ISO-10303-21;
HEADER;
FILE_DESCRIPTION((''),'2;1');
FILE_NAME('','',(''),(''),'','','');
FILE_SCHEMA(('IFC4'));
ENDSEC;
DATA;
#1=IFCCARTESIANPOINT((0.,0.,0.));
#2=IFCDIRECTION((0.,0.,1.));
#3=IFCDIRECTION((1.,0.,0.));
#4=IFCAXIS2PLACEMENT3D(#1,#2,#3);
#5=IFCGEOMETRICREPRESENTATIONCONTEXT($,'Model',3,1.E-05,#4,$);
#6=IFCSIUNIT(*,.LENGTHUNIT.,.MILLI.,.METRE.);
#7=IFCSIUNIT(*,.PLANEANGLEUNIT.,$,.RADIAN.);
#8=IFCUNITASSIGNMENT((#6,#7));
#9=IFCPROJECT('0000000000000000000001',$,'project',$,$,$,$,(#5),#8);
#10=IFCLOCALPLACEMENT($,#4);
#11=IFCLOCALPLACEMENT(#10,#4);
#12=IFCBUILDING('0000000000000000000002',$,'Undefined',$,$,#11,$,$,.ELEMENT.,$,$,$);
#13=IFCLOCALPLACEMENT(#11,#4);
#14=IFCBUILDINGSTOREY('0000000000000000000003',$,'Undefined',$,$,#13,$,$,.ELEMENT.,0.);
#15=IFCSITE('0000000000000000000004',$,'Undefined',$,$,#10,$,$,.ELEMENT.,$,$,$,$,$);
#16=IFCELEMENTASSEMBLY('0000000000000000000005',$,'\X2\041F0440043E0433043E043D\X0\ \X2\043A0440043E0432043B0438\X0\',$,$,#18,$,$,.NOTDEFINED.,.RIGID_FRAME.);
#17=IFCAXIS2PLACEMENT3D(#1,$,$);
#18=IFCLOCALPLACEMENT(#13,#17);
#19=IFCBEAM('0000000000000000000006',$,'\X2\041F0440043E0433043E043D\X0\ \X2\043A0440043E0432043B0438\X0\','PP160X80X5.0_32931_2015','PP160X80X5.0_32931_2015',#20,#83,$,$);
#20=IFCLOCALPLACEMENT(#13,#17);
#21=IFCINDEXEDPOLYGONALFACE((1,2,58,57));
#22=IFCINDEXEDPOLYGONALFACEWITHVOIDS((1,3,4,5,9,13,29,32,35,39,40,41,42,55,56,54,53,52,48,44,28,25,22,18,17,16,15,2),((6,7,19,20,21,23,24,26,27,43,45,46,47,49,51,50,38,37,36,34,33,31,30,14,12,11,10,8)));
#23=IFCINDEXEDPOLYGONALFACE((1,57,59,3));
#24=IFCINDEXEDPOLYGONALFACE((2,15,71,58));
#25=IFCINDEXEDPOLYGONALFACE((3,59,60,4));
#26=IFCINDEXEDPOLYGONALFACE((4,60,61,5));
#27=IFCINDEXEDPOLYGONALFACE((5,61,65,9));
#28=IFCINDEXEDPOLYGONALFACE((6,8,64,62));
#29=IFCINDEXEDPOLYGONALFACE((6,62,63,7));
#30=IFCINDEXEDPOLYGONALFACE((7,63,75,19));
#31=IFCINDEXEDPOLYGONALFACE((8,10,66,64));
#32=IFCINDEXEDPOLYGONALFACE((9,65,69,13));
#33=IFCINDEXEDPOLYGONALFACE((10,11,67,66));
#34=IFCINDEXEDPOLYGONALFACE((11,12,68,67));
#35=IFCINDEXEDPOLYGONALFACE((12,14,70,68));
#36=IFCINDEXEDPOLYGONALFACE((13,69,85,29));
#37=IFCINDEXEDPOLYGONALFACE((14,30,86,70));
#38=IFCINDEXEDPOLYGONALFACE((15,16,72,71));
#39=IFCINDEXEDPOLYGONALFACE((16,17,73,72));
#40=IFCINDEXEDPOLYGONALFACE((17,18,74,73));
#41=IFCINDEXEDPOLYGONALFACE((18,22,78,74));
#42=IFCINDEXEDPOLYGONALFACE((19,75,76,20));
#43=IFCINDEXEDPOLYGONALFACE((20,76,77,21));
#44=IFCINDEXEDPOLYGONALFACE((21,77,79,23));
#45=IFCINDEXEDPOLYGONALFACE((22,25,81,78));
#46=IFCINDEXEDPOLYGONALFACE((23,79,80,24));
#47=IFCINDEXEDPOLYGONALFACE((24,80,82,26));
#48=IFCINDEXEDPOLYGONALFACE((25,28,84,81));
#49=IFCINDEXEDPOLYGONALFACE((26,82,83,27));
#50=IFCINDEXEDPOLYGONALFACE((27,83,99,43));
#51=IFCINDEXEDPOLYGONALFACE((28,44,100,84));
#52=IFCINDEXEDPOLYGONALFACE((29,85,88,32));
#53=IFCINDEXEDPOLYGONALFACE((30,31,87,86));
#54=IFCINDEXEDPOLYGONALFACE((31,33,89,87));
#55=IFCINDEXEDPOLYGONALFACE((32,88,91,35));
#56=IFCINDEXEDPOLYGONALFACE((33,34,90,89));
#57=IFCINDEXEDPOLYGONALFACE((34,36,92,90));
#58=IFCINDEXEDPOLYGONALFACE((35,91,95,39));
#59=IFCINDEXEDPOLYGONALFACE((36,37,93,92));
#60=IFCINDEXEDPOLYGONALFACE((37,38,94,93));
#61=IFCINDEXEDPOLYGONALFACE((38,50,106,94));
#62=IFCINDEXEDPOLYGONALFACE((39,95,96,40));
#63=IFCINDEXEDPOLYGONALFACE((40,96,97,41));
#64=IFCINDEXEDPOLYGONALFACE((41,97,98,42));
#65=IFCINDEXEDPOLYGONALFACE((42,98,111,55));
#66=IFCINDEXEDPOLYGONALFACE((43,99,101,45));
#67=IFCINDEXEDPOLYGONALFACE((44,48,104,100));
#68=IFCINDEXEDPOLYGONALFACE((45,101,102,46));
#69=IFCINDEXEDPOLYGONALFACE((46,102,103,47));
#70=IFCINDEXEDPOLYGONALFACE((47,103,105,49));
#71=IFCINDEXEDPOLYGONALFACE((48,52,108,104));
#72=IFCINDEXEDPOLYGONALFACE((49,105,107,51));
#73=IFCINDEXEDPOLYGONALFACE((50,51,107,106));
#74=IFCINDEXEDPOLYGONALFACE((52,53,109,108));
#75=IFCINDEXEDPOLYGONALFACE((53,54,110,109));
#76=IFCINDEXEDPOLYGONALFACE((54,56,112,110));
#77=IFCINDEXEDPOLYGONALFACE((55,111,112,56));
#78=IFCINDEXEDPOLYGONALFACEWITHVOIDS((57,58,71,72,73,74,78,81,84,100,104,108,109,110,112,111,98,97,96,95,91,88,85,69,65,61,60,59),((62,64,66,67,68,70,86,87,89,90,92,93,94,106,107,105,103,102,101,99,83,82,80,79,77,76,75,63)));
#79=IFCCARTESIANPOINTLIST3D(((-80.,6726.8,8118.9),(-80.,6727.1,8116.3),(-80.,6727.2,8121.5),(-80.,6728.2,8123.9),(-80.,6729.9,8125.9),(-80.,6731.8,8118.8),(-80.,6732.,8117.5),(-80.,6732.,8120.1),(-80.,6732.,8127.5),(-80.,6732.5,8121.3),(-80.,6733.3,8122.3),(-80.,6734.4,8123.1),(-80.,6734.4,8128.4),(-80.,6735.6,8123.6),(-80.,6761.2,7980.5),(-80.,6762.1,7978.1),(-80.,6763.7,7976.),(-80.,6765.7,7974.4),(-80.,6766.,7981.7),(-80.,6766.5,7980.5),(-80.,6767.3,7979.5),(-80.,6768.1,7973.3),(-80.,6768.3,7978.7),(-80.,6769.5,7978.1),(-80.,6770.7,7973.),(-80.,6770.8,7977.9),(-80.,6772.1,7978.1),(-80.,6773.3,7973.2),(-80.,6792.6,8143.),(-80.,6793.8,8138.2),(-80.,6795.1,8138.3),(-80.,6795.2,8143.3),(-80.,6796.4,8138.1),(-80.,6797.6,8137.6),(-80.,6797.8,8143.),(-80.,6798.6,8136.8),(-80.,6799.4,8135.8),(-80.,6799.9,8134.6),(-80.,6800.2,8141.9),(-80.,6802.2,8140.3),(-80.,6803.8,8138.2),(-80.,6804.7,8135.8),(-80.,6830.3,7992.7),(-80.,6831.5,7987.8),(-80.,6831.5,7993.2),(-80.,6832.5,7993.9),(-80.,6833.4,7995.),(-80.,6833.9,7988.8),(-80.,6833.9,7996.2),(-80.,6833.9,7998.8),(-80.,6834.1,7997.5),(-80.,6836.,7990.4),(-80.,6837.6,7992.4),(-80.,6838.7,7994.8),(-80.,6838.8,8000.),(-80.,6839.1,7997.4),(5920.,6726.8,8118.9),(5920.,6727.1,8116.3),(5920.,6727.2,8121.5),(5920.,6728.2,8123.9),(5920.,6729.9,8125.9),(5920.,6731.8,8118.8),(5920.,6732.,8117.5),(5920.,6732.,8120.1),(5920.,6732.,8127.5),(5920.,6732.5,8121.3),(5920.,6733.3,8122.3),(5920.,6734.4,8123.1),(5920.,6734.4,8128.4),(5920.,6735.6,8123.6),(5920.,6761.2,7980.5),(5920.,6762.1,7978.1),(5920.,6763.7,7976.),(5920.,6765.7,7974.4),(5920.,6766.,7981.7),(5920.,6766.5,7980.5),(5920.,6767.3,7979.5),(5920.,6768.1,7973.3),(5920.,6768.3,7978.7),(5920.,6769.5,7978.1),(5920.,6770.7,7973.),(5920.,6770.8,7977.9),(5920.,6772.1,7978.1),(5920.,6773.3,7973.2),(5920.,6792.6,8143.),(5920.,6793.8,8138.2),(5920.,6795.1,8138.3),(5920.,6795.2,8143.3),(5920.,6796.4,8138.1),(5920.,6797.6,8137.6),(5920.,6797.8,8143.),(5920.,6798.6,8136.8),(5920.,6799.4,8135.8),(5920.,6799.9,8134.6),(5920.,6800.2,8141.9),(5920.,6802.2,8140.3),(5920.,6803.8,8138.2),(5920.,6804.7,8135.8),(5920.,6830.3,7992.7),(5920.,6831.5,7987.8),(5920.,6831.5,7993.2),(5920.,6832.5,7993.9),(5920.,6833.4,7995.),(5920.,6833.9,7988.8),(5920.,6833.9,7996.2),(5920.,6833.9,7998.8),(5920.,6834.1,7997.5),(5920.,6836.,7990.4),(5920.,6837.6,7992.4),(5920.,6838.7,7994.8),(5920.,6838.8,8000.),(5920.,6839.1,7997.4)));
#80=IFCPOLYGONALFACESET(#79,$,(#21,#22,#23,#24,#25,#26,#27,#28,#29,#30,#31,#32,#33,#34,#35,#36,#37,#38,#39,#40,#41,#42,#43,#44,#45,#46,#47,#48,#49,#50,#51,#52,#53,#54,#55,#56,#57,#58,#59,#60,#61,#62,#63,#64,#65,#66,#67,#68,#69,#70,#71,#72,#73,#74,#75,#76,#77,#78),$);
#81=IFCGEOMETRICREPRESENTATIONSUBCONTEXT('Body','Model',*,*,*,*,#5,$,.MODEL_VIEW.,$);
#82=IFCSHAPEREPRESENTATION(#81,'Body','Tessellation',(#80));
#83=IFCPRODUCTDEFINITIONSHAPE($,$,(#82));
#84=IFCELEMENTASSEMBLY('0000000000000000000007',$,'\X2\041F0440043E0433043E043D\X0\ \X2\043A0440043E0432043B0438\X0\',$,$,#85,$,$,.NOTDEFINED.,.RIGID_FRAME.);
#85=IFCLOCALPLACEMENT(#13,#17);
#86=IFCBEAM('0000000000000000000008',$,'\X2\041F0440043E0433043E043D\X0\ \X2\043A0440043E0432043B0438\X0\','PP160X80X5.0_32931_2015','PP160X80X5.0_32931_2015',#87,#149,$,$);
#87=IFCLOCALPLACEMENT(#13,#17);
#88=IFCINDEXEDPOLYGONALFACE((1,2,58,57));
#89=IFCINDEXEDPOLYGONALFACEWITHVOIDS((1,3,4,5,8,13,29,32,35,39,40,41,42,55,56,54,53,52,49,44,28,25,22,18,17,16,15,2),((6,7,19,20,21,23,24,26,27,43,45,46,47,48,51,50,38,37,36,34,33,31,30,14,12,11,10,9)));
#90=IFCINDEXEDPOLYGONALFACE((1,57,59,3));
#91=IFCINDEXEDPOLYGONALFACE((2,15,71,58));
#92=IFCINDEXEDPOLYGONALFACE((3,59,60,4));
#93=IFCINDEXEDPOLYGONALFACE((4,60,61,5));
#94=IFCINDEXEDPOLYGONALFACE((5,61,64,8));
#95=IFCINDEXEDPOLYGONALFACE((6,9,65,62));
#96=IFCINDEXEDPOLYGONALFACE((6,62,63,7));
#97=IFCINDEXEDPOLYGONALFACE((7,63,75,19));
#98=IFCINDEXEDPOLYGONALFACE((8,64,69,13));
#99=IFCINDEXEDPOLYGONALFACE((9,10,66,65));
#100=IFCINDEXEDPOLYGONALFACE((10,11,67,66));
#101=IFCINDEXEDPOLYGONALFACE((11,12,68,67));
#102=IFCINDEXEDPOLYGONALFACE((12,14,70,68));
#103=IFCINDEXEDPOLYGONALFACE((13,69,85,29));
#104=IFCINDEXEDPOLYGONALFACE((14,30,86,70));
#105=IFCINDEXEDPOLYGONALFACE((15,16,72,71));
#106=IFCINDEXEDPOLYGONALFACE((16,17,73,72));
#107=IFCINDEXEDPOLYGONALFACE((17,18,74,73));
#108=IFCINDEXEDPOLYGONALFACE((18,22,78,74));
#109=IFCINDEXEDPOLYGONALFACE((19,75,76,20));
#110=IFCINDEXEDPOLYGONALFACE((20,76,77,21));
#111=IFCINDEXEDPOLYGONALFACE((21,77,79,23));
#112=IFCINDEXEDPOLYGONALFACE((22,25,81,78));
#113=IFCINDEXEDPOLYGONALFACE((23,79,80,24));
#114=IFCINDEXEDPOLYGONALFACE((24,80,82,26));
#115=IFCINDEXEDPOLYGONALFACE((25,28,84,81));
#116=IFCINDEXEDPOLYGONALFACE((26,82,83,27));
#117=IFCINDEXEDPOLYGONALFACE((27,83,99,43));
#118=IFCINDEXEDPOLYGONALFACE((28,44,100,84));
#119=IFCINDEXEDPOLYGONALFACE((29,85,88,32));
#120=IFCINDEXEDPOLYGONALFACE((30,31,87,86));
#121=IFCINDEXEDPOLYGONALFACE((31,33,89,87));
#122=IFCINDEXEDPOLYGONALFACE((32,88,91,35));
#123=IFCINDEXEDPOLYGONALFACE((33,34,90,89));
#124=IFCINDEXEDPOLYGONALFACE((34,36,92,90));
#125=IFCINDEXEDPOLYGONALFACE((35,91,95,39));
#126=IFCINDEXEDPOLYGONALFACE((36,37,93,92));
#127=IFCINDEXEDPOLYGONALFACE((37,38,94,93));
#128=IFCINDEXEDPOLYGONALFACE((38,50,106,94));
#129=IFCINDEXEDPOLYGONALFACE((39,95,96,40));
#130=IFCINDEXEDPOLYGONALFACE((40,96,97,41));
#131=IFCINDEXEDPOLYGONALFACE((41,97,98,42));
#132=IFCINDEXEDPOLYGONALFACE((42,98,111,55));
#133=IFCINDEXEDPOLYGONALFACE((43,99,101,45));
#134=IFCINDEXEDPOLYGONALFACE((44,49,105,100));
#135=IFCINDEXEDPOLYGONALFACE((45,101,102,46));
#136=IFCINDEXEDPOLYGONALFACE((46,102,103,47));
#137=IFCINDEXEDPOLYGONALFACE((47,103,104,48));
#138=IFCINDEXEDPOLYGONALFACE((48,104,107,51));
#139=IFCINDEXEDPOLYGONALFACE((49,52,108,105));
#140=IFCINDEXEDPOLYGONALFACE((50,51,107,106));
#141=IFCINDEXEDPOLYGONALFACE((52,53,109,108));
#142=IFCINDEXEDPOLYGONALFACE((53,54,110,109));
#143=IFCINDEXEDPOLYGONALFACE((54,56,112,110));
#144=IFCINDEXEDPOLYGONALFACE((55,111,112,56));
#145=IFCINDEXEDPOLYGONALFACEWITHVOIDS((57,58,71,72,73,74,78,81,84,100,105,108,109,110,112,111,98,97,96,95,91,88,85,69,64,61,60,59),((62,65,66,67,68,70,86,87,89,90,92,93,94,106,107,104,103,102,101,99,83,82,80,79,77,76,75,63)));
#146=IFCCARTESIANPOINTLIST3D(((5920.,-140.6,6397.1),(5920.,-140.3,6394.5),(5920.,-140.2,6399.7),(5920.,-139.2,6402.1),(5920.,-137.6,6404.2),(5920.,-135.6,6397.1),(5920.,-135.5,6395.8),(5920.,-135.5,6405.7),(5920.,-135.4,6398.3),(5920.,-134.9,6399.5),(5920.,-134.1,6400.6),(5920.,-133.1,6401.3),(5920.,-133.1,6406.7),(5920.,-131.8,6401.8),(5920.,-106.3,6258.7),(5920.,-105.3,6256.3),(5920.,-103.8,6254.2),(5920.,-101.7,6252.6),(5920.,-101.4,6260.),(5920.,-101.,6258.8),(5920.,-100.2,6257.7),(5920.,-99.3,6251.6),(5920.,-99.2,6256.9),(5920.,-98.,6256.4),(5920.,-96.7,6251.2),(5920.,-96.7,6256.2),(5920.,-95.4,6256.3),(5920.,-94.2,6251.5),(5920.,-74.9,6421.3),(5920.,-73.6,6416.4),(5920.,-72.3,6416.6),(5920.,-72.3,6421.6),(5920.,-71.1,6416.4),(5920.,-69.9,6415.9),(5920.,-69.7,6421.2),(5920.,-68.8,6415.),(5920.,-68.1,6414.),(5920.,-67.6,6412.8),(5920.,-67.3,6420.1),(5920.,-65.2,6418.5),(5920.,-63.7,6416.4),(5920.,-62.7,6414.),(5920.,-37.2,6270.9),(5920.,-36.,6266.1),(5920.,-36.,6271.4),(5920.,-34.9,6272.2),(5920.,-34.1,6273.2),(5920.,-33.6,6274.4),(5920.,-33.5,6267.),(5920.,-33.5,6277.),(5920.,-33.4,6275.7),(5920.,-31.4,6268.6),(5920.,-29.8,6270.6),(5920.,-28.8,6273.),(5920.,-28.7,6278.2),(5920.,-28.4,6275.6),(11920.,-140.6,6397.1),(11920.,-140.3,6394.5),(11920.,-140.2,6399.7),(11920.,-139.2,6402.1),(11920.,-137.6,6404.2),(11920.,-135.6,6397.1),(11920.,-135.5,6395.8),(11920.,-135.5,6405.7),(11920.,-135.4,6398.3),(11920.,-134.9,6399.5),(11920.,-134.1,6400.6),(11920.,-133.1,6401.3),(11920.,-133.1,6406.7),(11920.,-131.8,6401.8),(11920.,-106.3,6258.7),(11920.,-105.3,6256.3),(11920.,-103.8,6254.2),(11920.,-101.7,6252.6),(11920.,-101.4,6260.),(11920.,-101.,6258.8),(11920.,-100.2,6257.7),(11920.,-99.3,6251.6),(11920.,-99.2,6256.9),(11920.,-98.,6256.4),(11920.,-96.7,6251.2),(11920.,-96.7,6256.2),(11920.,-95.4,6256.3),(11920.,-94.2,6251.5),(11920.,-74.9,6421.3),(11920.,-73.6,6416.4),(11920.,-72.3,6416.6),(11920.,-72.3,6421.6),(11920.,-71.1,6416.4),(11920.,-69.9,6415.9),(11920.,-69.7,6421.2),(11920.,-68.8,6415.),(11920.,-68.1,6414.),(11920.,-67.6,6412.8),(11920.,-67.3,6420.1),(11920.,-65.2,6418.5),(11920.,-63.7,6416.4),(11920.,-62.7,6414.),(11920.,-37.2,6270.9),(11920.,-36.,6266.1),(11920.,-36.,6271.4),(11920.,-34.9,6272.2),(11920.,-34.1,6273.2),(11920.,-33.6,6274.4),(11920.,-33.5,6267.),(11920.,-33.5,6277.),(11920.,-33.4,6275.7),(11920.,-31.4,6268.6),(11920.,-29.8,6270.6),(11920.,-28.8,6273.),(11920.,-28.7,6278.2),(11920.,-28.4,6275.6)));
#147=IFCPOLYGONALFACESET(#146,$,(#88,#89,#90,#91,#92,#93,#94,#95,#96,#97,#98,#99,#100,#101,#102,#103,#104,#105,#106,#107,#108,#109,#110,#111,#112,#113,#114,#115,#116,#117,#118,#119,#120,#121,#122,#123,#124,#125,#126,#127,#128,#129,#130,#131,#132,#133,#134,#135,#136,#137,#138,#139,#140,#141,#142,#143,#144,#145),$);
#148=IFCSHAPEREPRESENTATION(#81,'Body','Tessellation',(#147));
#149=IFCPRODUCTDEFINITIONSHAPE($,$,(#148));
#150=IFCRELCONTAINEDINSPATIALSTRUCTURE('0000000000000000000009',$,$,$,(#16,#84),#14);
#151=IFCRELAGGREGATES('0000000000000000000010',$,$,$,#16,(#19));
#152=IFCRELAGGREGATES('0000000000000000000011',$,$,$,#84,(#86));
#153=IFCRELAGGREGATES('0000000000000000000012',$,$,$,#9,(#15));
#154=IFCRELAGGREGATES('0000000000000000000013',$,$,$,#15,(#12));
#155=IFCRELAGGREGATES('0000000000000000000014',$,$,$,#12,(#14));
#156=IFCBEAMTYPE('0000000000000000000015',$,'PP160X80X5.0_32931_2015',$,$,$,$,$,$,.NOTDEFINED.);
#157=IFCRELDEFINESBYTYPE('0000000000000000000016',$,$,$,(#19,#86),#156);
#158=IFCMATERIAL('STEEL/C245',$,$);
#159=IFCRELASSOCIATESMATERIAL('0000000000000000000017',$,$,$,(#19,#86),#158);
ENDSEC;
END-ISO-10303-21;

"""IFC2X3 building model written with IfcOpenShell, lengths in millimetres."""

from ifc_helpers import new_model, si_unit, frame, origin_with_axes, origin_2d_with_axis, place, context, subcontext, project, spatial, hollow_rectangle, extrude, material, type_object, element, aggregate, save


model = new_model("IFC2X3")

# Units and contexts
model_context = context("Model", 3, precision=1e-05, world=origin_with_axes())
body_context = subcontext(model_context, "Body", "Model", "MODEL_VIEW")
ifc_project = project(units=[si_unit("LENGTHUNIT", "METRE", prefix="MILLI"), si_unit("PLANEANGLEUNIT", "RADIAN")], contexts=[model_context])

# Site, building, storey
site_placement = place(None, origin_with_axes())
site = spatial("IfcSite", under=ifc_project, at=site_placement, Name="Undefined", CompositionType="ELEMENT")
building_placement = place(site_placement, origin_with_axes())
building = spatial("IfcBuilding", under=site, at=building_placement, Name="Undefined", CompositionType="ELEMENT")
storey_placement = place(building_placement, origin_with_axes())
storey = spatial("IfcBuildingStorey", under=building, at=storey_placement, Name="Undefined", CompositionType="ELEMENT", Elevation=0.0)

# Shared definitions
ifc_material = material(Name="STEEL/C245")

# Element assemblies, beams
beam_type_1 = type_object("IfcBeamType", Name="PP160X80X5.0_32931_2015", PredefinedType="NOTDEFINED")
assembly_1_placement = place(storey_placement, origin_with_axes())
assembly_1 = element("IfcElementAssembly", 1, at=assembly_1_placement, inside=storey, Name="Прогон кровли", AssemblyPlace="NOTDEFINED", PredefinedType="RIGID_FRAME")
beam_1_placement = place(assembly_1_placement, frame((-80.0, 6782.9, 8058.1), z_axis=(0.0, -0.243188, 0.969979), x_axis=(1.0, 0.0, 0.0)))
beam_1 = element("IfcBeam", 2, at=beam_1_placement, type_object=beam_type_1, material=ifc_material, Name="Прогон кровли", Description="PP160X80X5.0_32931_2015", ObjectType="PP160X80X5.0_32931_2015", context=body_context, shape_type="SweptSolid", body=[
    extrude(hollow_rectangle(XDim=80.0, YDim=160.0, WallThickness=5.0, InnerFilletRadius=5.0, OuterFilletRadius=10.0, at=origin_2d_with_axis()), frame((6000.0, 0.0, 0.0), z_axis=(-1.0, 0.0, 0.0), x_axis=(0.0, -1.0, 0.0)), (0.0, 0.0, 1.0), 6000.0),
])
aggregate(assembly_1, [beam_1])
assembly_2_placement = place(storey_placement, origin_with_axes())
assembly_2 = element("IfcElementAssembly", 3, at=assembly_2_placement, inside=storey, Name="Прогон кровли", AssemblyPlace="NOTDEFINED", PredefinedType="RIGID_FRAME")
beam_2_placement = place(assembly_2_placement, frame((5920.0, -84.5, 6336.4), z_axis=(0.0, -0.243188, 0.969979), x_axis=(1.0, 0.0, 0.0)))
beam_2 = element("IfcBeam", 4, at=beam_2_placement, type_object=beam_type_1, material=ifc_material, Name="Прогон кровли", Description="PP160X80X5.0_32931_2015", ObjectType="PP160X80X5.0_32931_2015", context=body_context, shape_type="SweptSolid", body=[
    extrude(hollow_rectangle(XDim=80.0, YDim=160.0, WallThickness=5.0, InnerFilletRadius=5.0, OuterFilletRadius=10.0, at=origin_2d_with_axis()), frame((6000.0, 0.0, 0.0), z_axis=(-1.0, 0.0, 0.0), x_axis=(0.0, -1.0, 0.0)), (0.0, 0.0, 1.0), 6000.0),
])
aggregate(assembly_2, [beam_2])

save(model, "model.ifc")
